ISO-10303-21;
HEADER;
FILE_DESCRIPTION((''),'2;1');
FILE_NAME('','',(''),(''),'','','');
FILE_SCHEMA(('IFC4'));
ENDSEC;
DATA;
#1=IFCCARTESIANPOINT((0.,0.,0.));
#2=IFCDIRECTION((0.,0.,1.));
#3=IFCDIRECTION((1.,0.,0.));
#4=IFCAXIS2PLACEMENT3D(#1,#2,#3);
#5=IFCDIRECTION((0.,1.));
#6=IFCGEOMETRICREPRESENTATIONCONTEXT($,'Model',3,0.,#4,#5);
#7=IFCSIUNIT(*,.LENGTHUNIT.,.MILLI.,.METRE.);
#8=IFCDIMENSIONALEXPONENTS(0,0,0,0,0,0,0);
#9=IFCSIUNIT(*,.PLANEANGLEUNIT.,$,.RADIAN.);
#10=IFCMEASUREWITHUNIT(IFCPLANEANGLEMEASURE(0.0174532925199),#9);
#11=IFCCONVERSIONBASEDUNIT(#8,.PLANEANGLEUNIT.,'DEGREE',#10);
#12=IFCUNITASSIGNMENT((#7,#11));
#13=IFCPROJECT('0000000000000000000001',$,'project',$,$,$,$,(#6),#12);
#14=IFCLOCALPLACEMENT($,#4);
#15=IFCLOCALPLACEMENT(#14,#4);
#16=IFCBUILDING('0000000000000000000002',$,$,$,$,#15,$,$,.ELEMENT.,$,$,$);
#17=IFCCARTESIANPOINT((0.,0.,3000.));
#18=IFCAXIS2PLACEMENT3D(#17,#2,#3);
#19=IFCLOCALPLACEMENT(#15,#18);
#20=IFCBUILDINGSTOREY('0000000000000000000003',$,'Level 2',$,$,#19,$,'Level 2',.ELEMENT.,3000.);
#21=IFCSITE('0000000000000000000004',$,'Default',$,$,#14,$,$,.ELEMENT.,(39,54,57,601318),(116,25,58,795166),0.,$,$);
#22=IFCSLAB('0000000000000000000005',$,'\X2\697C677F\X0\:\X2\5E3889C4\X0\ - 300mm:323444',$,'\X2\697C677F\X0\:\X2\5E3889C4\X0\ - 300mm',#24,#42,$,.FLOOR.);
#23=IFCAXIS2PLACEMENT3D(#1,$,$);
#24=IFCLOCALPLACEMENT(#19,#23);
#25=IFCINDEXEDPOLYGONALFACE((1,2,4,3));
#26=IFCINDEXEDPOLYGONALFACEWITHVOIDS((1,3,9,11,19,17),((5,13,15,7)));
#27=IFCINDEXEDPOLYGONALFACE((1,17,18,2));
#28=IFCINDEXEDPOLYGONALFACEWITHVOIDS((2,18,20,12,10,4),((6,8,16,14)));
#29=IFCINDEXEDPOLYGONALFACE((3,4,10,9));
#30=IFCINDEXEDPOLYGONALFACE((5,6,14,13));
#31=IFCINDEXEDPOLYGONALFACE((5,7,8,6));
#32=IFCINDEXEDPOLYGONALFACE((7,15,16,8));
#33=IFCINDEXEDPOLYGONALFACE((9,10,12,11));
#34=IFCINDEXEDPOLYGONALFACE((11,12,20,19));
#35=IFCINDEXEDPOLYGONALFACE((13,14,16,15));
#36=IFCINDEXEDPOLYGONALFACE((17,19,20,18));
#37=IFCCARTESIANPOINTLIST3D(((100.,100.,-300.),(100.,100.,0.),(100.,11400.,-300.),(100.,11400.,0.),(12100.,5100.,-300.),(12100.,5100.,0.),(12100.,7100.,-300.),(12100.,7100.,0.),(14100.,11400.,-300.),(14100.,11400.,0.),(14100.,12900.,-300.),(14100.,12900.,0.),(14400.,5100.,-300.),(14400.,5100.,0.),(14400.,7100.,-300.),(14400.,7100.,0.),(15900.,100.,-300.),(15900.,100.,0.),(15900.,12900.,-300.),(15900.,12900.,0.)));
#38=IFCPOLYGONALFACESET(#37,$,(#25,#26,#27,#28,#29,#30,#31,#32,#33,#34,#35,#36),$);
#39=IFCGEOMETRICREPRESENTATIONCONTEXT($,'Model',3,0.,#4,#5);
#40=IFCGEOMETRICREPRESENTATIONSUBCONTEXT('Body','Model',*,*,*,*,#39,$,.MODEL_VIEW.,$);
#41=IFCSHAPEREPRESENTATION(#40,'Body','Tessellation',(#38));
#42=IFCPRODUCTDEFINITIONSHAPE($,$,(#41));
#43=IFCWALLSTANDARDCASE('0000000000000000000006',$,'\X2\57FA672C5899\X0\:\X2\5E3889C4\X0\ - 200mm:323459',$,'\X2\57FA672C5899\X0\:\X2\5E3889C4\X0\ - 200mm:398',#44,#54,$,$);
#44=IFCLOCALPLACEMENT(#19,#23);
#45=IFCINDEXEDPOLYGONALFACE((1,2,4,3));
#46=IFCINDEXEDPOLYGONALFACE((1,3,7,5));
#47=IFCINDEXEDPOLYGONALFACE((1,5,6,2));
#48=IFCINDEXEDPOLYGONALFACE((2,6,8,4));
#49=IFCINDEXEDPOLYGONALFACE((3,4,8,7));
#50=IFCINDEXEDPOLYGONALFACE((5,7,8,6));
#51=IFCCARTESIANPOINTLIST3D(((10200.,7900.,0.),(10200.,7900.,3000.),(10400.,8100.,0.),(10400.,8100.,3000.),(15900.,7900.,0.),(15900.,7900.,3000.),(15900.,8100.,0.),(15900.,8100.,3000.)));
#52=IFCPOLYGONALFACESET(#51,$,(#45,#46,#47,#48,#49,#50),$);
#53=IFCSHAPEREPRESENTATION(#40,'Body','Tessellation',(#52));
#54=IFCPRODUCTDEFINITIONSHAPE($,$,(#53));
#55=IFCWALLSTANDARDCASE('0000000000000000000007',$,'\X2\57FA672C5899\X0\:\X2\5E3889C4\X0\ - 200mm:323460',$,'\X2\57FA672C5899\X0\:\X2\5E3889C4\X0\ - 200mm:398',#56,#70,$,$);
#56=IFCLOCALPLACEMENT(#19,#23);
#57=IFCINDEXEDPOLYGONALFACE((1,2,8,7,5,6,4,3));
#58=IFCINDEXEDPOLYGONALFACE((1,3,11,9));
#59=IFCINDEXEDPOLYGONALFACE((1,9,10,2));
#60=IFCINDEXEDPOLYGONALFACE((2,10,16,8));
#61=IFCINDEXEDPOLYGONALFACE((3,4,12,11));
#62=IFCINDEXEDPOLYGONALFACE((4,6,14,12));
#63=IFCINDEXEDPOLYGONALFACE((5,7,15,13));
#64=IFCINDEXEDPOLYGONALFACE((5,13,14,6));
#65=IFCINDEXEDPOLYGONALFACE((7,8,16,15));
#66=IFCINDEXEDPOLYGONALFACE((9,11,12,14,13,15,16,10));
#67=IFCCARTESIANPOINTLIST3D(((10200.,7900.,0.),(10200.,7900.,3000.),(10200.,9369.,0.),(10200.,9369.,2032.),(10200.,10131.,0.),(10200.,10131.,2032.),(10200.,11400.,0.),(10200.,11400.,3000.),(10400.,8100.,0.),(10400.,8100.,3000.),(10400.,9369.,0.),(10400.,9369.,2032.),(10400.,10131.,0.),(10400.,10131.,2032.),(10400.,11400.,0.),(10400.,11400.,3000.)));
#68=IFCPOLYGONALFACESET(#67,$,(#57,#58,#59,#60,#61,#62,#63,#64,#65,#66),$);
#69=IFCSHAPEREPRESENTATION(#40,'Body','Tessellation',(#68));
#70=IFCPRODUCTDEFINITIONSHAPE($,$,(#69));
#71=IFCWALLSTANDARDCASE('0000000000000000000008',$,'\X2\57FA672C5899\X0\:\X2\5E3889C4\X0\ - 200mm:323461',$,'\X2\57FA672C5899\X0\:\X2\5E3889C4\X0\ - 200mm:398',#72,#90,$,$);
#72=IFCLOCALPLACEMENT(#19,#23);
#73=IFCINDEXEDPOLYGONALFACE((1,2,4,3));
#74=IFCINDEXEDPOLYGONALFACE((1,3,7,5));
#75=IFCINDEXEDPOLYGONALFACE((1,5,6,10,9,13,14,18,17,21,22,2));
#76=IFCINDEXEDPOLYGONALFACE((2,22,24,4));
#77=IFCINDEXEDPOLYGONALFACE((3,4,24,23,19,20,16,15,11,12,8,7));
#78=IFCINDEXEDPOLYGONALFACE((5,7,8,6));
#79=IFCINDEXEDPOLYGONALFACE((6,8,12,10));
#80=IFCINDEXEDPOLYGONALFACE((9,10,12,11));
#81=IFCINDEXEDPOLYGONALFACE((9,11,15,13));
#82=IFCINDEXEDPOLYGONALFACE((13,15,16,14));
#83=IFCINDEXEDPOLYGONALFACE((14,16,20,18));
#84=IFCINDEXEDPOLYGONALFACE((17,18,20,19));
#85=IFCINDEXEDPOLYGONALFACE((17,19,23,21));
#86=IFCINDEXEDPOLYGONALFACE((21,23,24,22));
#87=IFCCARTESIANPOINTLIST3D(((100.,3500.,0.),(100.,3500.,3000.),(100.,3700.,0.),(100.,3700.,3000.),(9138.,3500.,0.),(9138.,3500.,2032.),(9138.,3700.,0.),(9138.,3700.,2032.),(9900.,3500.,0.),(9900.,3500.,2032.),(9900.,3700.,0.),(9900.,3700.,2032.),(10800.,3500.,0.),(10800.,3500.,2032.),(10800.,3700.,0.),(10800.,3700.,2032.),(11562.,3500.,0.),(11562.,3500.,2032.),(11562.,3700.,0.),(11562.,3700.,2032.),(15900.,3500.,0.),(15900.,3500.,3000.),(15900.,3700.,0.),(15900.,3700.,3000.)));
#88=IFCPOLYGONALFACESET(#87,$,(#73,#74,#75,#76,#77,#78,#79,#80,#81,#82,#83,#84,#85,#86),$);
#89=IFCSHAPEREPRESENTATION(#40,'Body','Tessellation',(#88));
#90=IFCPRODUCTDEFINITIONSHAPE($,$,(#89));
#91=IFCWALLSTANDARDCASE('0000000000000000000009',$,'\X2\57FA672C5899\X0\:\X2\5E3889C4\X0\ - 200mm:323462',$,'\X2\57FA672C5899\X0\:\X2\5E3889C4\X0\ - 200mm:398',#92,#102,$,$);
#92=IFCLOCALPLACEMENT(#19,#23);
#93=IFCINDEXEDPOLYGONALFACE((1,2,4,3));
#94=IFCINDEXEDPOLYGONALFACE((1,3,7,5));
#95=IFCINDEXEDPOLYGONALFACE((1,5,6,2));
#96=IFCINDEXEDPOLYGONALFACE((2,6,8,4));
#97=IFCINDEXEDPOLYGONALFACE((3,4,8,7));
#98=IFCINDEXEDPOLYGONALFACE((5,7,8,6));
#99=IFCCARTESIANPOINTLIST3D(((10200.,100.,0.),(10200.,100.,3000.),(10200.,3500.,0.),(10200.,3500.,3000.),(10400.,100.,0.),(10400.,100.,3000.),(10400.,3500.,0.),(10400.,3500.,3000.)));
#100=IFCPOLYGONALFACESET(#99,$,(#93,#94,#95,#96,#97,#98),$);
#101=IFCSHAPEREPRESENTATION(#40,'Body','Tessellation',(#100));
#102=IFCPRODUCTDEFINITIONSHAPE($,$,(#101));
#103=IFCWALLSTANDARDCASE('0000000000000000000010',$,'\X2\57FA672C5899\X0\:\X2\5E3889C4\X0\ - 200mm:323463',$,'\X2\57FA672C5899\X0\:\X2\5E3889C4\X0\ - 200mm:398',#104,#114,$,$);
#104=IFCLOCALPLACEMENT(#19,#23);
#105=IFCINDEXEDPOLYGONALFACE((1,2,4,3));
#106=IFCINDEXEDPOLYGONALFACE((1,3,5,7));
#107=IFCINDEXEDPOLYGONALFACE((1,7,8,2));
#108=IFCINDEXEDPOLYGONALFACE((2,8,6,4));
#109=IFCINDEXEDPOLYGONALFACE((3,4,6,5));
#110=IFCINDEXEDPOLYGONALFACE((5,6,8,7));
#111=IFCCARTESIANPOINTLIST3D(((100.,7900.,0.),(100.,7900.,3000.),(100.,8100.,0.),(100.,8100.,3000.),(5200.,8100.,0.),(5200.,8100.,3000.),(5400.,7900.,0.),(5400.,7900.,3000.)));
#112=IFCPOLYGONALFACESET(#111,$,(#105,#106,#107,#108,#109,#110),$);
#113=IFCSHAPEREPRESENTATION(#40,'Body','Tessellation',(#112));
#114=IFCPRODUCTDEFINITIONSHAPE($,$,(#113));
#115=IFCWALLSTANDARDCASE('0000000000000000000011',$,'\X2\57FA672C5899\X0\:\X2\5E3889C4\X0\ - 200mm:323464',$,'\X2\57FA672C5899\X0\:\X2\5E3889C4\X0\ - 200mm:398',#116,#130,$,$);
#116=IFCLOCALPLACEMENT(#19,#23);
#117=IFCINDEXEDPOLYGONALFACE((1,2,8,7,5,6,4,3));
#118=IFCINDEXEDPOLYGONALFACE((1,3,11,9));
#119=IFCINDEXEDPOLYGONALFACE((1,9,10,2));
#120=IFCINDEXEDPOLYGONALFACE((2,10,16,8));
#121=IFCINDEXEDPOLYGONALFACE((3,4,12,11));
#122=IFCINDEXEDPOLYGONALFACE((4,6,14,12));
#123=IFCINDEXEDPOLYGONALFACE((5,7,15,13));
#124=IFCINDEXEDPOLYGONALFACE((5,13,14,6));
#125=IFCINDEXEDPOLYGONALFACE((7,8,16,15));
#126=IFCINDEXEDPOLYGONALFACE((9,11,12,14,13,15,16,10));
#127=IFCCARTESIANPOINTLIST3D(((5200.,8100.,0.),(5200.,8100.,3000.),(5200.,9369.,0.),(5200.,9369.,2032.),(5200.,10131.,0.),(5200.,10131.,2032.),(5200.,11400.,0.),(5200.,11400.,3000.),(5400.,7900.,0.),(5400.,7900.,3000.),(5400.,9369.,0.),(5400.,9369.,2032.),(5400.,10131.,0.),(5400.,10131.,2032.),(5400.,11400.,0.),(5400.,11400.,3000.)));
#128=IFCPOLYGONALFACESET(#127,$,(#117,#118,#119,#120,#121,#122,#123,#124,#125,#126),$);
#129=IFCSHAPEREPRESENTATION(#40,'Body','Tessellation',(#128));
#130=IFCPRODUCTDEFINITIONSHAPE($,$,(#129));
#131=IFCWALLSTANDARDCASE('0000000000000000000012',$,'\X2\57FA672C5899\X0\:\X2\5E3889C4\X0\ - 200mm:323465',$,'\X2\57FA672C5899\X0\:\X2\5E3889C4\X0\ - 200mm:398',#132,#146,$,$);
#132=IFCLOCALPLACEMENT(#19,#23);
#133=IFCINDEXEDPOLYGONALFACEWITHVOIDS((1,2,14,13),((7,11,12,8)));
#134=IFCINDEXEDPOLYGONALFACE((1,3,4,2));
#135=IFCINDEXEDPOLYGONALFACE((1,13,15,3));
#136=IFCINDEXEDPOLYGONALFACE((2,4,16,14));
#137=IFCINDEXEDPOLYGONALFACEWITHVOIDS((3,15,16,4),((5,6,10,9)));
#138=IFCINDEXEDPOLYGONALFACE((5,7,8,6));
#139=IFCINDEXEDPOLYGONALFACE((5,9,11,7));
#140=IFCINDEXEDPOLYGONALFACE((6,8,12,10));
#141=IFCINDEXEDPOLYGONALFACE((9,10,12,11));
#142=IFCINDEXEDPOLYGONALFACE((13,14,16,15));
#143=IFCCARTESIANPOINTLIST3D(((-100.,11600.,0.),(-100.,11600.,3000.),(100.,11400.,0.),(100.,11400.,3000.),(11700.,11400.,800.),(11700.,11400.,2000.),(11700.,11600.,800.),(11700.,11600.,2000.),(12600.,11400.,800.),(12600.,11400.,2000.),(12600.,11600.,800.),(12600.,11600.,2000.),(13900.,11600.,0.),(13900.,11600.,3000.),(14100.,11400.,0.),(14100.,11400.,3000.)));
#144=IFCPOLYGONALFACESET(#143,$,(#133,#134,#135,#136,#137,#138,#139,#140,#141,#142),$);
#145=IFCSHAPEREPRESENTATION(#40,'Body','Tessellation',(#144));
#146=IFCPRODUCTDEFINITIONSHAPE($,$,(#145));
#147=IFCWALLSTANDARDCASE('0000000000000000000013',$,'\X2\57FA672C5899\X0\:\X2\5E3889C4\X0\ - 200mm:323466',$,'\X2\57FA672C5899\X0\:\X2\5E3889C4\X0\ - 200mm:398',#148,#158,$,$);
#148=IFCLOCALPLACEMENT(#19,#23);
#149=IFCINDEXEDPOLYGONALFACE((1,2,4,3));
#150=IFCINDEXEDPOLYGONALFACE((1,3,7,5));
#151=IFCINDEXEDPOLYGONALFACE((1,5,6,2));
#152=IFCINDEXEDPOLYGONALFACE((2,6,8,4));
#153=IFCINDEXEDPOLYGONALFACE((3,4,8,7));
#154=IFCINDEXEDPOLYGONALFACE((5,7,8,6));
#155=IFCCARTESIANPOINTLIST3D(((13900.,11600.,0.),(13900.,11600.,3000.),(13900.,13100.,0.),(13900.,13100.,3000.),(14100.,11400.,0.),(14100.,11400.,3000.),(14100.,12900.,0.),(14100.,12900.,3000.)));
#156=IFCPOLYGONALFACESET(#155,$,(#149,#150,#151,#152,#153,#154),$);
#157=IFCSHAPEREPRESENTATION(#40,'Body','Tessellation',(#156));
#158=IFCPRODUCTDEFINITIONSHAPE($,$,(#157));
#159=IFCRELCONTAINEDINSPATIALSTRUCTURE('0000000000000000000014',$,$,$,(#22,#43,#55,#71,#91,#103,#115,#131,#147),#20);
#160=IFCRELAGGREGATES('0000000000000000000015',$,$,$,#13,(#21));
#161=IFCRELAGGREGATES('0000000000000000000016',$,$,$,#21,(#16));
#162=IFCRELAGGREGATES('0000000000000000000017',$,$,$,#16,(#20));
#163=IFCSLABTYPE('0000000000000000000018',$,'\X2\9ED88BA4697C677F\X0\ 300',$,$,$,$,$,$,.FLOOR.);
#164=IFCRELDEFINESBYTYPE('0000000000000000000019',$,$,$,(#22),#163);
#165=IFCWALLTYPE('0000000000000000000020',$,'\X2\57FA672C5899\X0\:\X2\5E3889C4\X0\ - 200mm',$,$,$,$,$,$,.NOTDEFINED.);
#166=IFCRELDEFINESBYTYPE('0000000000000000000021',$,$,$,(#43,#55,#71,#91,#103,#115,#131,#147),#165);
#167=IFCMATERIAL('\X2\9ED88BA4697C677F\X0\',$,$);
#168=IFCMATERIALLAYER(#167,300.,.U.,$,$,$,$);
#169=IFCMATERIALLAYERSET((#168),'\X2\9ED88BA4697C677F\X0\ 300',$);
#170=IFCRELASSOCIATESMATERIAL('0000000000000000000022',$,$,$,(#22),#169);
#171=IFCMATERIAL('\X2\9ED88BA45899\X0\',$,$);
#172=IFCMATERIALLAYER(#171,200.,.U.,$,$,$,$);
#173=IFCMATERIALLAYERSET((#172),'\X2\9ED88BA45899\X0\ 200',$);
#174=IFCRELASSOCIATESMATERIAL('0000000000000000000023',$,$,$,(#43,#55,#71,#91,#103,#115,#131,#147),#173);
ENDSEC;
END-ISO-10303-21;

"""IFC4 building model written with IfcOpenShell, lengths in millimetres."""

from ifc_helpers import new_model, entity, si_unit, converted_unit, direction, frame, origin_with_axes, place, context, subcontext, project, spatial, polyline, outline, extrude, material, layer, layer_set, layer_usage, type_object, element, save


model = new_model("IFC4")

# Units and contexts
model_context_1 = context("Model", 3, precision=0.0, world=origin_with_axes(), true_north=direction((0.0, 1.0)))
model_context_2 = context("Model", 3, precision=0.0, world=origin_with_axes(), true_north=direction((0.0, 1.0)))
body_context = subcontext(model_context_2, "Body", "Model", "MODEL_VIEW")
ifc_project = project(units=[si_unit("LENGTHUNIT", "METRE", prefix="MILLI"), converted_unit("PLANEANGLEUNIT", "DEGREE", entity("IfcPlaneAngleMeasure", 0.0174532925199), si_unit("PLANEANGLEUNIT", "RADIAN"), dimensions=[0, 0, 0, 0, 0, 0, 0])], contexts=[model_context_1])

# Site, building, storey
site_placement = place(None, origin_with_axes())
site = spatial("IfcSite", under=ifc_project, at=site_placement, Name="Default", CompositionType="ELEMENT", RefLatitude=(39, 54, 57, 601318), RefLongitude=(116, 25, 58, 795166), RefElevation=0.0)
building_placement = place(site_placement, origin_with_axes())
building = spatial("IfcBuilding", under=site, at=building_placement, CompositionType="ELEMENT")
storey_placement = place(building_placement, frame((0.0, 0.0, 3000.0), z_axis=(0.0, 0.0, 1.0), x_axis=(1.0, 0.0, 0.0)))
storey = spatial("IfcBuildingStorey", under=building, at=storey_placement, Name="Level 2", LongName="Level 2", CompositionType="ELEMENT", Elevation=3000.0)

# Slab, opening
ifc_material_1 = material(Name="默认楼板")
ifc_layer_1 = layer(ifc_material_1, 300.0, ventilated="UNKNOWN")
ifc_layer_set_1 = layer_set([ifc_layer_1], Name="默认楼板 300")
ifc_layer_usage_1 = layer_usage(ifc_layer_set_1, "AXIS3", "NEGATIVE", 300.0)
slab_type = type_object("IfcSlabType", Name="默认楼板 300", PredefinedType="FLOOR")
slab_placement = place(storey_placement, frame((15900.0, 12900.0, -300.0), z_axis=(0.0, 0.0, 1.0), x_axis=(1.0, 0.0, 0.0)))
slab = element("IfcSlab", 1, at=slab_placement, inside=storey, type_object=slab_type, material=ifc_layer_usage_1, Name="楼板:常规 - 300mm:323444", ObjectType="楼板:常规 - 300mm", PredefinedType="FLOOR", context=body_context, shape_type="SweptSolid", body=[
    extrude(outline(polyline([(0.0, 0.0), (-1800.0, 0.0), (-1800.0, -1500.0), (-15800.0, -1500.0), (-15800.0, -12800.0), (0.0, -12800.0), (0.0, 0.0)])), origin_with_axes(), (0.0, 0.0, 1.0), 300.0),
])
opening_1_placement = place(slab_placement, origin_with_axes())
element("IfcOpeningElement", 2, at=opening_1_placement, cuts=slab, context=body_context, shape_type="SweptSolid", body=[
    extrude(outline(polyline([(-3800.0, -7800.0), (-1500.0, -7800.0), (-1500.0, -5800.0), (-3800.0, -5800.0), (-3800.0, -7800.0)])), origin_with_axes(), (0.0, 0.0, 1.0), 300.0),
])

# Wall
ifc_material_2 = material(Name="默认墙")
ifc_layer_2 = layer(ifc_material_2, 200.0, ventilated="UNKNOWN")
ifc_layer_set_2 = layer_set([ifc_layer_2], Name="默认墙 200")
ifc_layer_usage_2 = layer_usage(ifc_layer_set_2, "AXIS2", "POSITIVE", -100.0)
wall_type = type_object("IfcWallType", Name="基本墙:常规 - 200mm", PredefinedType="NOTDEFINED")
wall_1_placement = place(storey_placement, frame((10300.0, 8000.0, 0.0), z_axis=(0.0, 0.0, 1.0), x_axis=(1.0, 0.0, 0.0)))
element("IfcWallStandardCase", 3, at=wall_1_placement, inside=storey, type_object=wall_type, material=ifc_layer_usage_2, Name="基本墙:常规 - 200mm:323459", ObjectType="基本墙:常规 - 200mm:398", context=body_context, shape_type="SweptSolid", body=[
    extrude(outline(polyline([(-100.0, -100.0), (5600.0, -100.0), (5600.0, 100.0), (100.0, 100.0), (-100.0, -100.0)])), origin_with_axes(), (0.0, 0.0, 1.0), 3000.0),
])

# Wall, opening
ifc_layer_usage_3 = layer_usage(ifc_layer_set_2, "AXIS2", "POSITIVE", -100.0)
wall_2_placement = place(storey_placement, frame((10300.0, 11500.0, 0.0), z_axis=(0.0, 0.0, 1.0), x_axis=(0.0, -1.0, 0.0)))
wall_2 = element("IfcWallStandardCase", 4, at=wall_2_placement, inside=storey, type_object=wall_type, material=ifc_layer_usage_3, Name="基本墙:常规 - 200mm:323460", ObjectType="基本墙:常规 - 200mm:398", context=body_context, shape_type="SweptSolid", body=[
    extrude(outline(polyline([(100.0, -100.0), (3600.0, -100.0), (3400.0, 100.0), (100.0, 100.0), (100.0, -100.0)])), origin_with_axes(), (0.0, 0.0, 1.0), 3000.0),
])
opening_2_placement = place(wall_2_placement, frame((1750.0, 0.0, 0.0), z_axis=(0.0, 0.0, 1.0), x_axis=(1.0, 0.0, 0.0)))
element("IfcOpeningElement", 5, at=opening_2_placement, cuts=wall_2, context=body_context, shape_type="SweptSolid", body=[
    extrude(outline(polyline([(-381.0, -2032.0), (381.0, -2032.0), (381.0, 0.0), (-381.0, 0.0), (-381.0, -2032.0)])), frame((0.0, 100.0, 0.0), z_axis=(0.0, -1.0, 0.0), x_axis=(-1.0, 0.0, 0.0)), (0.0, 0.0, 1.0), 200.0),
])

# Wall, openings
ifc_layer_usage_4 = layer_usage(ifc_layer_set_2, "AXIS2", "POSITIVE", -100.0)
wall_3_placement = place(storey_placement, frame((16000.0, 3600.0, 0.0), z_axis=(0.0, 0.0, 1.0), x_axis=(-1.0, 0.0, 0.0)))
wall_3 = element("IfcWallStandardCase", 6, at=wall_3_placement, inside=storey, type_object=wall_type, material=ifc_layer_usage_4, Name="基本墙:常规 - 200mm:323461", ObjectType="基本墙:常规 - 200mm:398", context=body_context, shape_type="SweptSolid", body=[
    extrude(outline(polyline([(100.0, -100.0), (15900.0, -100.0), (15900.0, 100.0), (100.0, 100.0), (100.0, -100.0)])), origin_with_axes(), (0.0, 0.0, 1.0), 3000.0),
])
opening_3_placement = place(wall_3_placement, frame((6481.0, 0.0, 0.0), z_axis=(0.0, 0.0, 1.0), x_axis=(1.0, 0.0, 0.0)))
element("IfcOpeningElement", 7, at=opening_3_placement, cuts=wall_3, context=body_context, shape_type="SweptSolid", body=[
    extrude(outline(polyline([(-381.0, 0.0), (-381.0, -2032.0), (381.0, -2032.0), (381.0, 0.0), (-381.0, 0.0)])), frame((0.0, 100.0, 0.0), z_axis=(0.0, 1.0, 0.0), x_axis=(1.0, 0.0, 0.0)), (0.0, 0.0, -1.0), 200.0),
])
opening_4_placement = place(wall_3_placement, frame((4819.0, 0.0, 0.0), z_axis=(0.0, 0.0, 1.0), x_axis=(1.0, 0.0, 0.0)))
element("IfcOpeningElement", 8, at=opening_4_placement, cuts=wall_3, context=body_context, shape_type="SweptSolid", body=[
    extrude(outline(polyline([(-381.0, -2032.0), (381.0, -2032.0), (381.0, 0.0), (-381.0, 0.0), (-381.0, -2032.0)])), frame((0.0, 100.0, 0.0), z_axis=(0.0, -1.0, 0.0), x_axis=(-1.0, 0.0, 0.0)), (0.0, 0.0, 1.0), 200.0),
])

# Walls
ifc_layer_usage_5 = layer_usage(ifc_layer_set_2, "AXIS2", "POSITIVE", -100.0)
wall_4_placement = place(storey_placement, frame((10300.0, 3600.0, 0.0), z_axis=(0.0, 0.0, 1.0), x_axis=(0.0, -1.0, 0.0)))
element("IfcWallStandardCase", 9, at=wall_4_placement, inside=storey, type_object=wall_type, material=ifc_layer_usage_5, Name="基本墙:常规 - 200mm:323462", ObjectType="基本墙:常规 - 200mm:398", context=body_context, shape_type="SweptSolid", body=[
    extrude(outline(polyline([(100.0, -100.0), (3500.0, -100.0), (3500.0, 100.0), (100.0, 100.0), (100.0, -100.0)])), origin_with_axes(), (0.0, 0.0, 1.0), 3000.0),
])
ifc_layer_usage_6 = layer_usage(ifc_layer_set_2, "AXIS2", "POSITIVE", -100.0)
wall_5_placement = place(storey_placement, frame((0.0, 8000.0, 0.0), z_axis=(0.0, 0.0, 1.0), x_axis=(1.0, 0.0, 0.0)))
element("IfcWallStandardCase", 10, at=wall_5_placement, inside=storey, type_object=wall_type, material=ifc_layer_usage_6, Name="基本墙:常规 - 200mm:323463", ObjectType="基本墙:常规 - 200mm:398", context=body_context, shape_type="SweptSolid", body=[
    extrude(outline(polyline([(100.0, -100.0), (5400.0, -100.0), (5200.0, 100.0), (100.0, 100.0), (100.0, -100.0)])), origin_with_axes(), (0.0, 0.0, 1.0), 3000.0),
])

# Walls, openings
ifc_layer_usage_7 = layer_usage(ifc_layer_set_2, "AXIS2", "POSITIVE", -100.0)
wall_6_placement = place(storey_placement, frame((5300.0, 8000.0, 0.0), z_axis=(0.0, 0.0, 1.0), x_axis=(0.0, 1.0, 0.0)))
wall_6 = element("IfcWallStandardCase", 11, at=wall_6_placement, inside=storey, type_object=wall_type, material=ifc_layer_usage_7, Name="基本墙:常规 - 200mm:323464", ObjectType="基本墙:常规 - 200mm:398", context=body_context, shape_type="SweptSolid", body=[
    extrude(outline(polyline([(-100.0, -100.0), (3400.0, -100.0), (3400.0, 100.0), (100.0, 100.0), (-100.0, -100.0)])), origin_with_axes(), (0.0, 0.0, 1.0), 3000.0),
])
opening_5_placement = place(wall_6_placement, frame((1750.0, 0.0, 0.0), z_axis=(0.0, 0.0, 1.0), x_axis=(1.0, 0.0, 0.0)))
element("IfcOpeningElement", 12, at=opening_5_placement, cuts=wall_6, context=body_context, shape_type="SweptSolid", body=[
    extrude(outline(polyline([(-381.0, -2032.0), (381.0, -2032.0), (381.0, 0.0), (-381.0, 0.0), (-381.0, -2032.0)])), frame((0.0, 100.0, 0.0), z_axis=(0.0, -1.0, 0.0), x_axis=(-1.0, 0.0, 0.0)), (0.0, 0.0, 1.0), 200.0),
])
ifc_layer_usage_8 = layer_usage(ifc_layer_set_2, "AXIS2", "POSITIVE", -100.0)
wall_7_placement = place(storey_placement, frame((0.0, 11500.0, 0.0), z_axis=(0.0, 0.0, 1.0), x_axis=(1.0, 0.0, 0.0)))
wall_7 = element("IfcWallStandardCase", 13, at=wall_7_placement, inside=storey, type_object=wall_type, material=ifc_layer_usage_8, Name="基本墙:常规 - 200mm:323465", ObjectType="基本墙:常规 - 200mm:398", context=body_context, shape_type="SweptSolid", body=[
    extrude(outline(polyline([(100.0, -100.0), (14100.0, -100.0), (13900.0, 100.0), (-100.0, 100.0), (100.0, -100.0)])), origin_with_axes(), (0.0, 0.0, 1.0), 3000.0),
])
opening_6_placement = place(wall_7_placement, frame((12150.0, 0.0, 800.0), z_axis=(0.0, 0.0, 1.0), x_axis=(1.0, 0.0, 0.0)))
element("IfcOpeningElement", 14, at=opening_6_placement, cuts=wall_7, context=body_context, shape_type="SweptSolid", body=[
    extrude(outline(polyline([(450.0, -1200.0), (450.0, 0.0), (-450.0, 0.0), (-450.0, -1200.0), (450.0, -1200.0)])), frame((0.0, 100.0, 0.0), z_axis=(0.0, -1.0, 0.0), x_axis=(-1.0, 0.0, 0.0)), (0.0, 0.0, 1.0), 200.0),
])

# Wall
ifc_layer_usage_9 = layer_usage(ifc_layer_set_2, "AXIS2", "POSITIVE", -100.0)
wall_8_placement = place(storey_placement, frame((14000.0, 11500.0, 0.0), z_axis=(0.0, 0.0, 1.0), x_axis=(0.0, 1.0, 0.0)))
element("IfcWallStandardCase", 15, at=wall_8_placement, inside=storey, type_object=wall_type, material=ifc_layer_usage_9, Name="基本墙:常规 - 200mm:323466", ObjectType="基本墙:常规 - 200mm:398", context=body_context, shape_type="SweptSolid", body=[
    extrude(outline(polyline([(-100.0, -100.0), (1400.0, -100.0), (1600.0, 100.0), (100.0, 100.0), (-100.0, -100.0)])), origin_with_axes(), (0.0, 0.0, 1.0), 3000.0),
])

save(model, "model.ifc")
